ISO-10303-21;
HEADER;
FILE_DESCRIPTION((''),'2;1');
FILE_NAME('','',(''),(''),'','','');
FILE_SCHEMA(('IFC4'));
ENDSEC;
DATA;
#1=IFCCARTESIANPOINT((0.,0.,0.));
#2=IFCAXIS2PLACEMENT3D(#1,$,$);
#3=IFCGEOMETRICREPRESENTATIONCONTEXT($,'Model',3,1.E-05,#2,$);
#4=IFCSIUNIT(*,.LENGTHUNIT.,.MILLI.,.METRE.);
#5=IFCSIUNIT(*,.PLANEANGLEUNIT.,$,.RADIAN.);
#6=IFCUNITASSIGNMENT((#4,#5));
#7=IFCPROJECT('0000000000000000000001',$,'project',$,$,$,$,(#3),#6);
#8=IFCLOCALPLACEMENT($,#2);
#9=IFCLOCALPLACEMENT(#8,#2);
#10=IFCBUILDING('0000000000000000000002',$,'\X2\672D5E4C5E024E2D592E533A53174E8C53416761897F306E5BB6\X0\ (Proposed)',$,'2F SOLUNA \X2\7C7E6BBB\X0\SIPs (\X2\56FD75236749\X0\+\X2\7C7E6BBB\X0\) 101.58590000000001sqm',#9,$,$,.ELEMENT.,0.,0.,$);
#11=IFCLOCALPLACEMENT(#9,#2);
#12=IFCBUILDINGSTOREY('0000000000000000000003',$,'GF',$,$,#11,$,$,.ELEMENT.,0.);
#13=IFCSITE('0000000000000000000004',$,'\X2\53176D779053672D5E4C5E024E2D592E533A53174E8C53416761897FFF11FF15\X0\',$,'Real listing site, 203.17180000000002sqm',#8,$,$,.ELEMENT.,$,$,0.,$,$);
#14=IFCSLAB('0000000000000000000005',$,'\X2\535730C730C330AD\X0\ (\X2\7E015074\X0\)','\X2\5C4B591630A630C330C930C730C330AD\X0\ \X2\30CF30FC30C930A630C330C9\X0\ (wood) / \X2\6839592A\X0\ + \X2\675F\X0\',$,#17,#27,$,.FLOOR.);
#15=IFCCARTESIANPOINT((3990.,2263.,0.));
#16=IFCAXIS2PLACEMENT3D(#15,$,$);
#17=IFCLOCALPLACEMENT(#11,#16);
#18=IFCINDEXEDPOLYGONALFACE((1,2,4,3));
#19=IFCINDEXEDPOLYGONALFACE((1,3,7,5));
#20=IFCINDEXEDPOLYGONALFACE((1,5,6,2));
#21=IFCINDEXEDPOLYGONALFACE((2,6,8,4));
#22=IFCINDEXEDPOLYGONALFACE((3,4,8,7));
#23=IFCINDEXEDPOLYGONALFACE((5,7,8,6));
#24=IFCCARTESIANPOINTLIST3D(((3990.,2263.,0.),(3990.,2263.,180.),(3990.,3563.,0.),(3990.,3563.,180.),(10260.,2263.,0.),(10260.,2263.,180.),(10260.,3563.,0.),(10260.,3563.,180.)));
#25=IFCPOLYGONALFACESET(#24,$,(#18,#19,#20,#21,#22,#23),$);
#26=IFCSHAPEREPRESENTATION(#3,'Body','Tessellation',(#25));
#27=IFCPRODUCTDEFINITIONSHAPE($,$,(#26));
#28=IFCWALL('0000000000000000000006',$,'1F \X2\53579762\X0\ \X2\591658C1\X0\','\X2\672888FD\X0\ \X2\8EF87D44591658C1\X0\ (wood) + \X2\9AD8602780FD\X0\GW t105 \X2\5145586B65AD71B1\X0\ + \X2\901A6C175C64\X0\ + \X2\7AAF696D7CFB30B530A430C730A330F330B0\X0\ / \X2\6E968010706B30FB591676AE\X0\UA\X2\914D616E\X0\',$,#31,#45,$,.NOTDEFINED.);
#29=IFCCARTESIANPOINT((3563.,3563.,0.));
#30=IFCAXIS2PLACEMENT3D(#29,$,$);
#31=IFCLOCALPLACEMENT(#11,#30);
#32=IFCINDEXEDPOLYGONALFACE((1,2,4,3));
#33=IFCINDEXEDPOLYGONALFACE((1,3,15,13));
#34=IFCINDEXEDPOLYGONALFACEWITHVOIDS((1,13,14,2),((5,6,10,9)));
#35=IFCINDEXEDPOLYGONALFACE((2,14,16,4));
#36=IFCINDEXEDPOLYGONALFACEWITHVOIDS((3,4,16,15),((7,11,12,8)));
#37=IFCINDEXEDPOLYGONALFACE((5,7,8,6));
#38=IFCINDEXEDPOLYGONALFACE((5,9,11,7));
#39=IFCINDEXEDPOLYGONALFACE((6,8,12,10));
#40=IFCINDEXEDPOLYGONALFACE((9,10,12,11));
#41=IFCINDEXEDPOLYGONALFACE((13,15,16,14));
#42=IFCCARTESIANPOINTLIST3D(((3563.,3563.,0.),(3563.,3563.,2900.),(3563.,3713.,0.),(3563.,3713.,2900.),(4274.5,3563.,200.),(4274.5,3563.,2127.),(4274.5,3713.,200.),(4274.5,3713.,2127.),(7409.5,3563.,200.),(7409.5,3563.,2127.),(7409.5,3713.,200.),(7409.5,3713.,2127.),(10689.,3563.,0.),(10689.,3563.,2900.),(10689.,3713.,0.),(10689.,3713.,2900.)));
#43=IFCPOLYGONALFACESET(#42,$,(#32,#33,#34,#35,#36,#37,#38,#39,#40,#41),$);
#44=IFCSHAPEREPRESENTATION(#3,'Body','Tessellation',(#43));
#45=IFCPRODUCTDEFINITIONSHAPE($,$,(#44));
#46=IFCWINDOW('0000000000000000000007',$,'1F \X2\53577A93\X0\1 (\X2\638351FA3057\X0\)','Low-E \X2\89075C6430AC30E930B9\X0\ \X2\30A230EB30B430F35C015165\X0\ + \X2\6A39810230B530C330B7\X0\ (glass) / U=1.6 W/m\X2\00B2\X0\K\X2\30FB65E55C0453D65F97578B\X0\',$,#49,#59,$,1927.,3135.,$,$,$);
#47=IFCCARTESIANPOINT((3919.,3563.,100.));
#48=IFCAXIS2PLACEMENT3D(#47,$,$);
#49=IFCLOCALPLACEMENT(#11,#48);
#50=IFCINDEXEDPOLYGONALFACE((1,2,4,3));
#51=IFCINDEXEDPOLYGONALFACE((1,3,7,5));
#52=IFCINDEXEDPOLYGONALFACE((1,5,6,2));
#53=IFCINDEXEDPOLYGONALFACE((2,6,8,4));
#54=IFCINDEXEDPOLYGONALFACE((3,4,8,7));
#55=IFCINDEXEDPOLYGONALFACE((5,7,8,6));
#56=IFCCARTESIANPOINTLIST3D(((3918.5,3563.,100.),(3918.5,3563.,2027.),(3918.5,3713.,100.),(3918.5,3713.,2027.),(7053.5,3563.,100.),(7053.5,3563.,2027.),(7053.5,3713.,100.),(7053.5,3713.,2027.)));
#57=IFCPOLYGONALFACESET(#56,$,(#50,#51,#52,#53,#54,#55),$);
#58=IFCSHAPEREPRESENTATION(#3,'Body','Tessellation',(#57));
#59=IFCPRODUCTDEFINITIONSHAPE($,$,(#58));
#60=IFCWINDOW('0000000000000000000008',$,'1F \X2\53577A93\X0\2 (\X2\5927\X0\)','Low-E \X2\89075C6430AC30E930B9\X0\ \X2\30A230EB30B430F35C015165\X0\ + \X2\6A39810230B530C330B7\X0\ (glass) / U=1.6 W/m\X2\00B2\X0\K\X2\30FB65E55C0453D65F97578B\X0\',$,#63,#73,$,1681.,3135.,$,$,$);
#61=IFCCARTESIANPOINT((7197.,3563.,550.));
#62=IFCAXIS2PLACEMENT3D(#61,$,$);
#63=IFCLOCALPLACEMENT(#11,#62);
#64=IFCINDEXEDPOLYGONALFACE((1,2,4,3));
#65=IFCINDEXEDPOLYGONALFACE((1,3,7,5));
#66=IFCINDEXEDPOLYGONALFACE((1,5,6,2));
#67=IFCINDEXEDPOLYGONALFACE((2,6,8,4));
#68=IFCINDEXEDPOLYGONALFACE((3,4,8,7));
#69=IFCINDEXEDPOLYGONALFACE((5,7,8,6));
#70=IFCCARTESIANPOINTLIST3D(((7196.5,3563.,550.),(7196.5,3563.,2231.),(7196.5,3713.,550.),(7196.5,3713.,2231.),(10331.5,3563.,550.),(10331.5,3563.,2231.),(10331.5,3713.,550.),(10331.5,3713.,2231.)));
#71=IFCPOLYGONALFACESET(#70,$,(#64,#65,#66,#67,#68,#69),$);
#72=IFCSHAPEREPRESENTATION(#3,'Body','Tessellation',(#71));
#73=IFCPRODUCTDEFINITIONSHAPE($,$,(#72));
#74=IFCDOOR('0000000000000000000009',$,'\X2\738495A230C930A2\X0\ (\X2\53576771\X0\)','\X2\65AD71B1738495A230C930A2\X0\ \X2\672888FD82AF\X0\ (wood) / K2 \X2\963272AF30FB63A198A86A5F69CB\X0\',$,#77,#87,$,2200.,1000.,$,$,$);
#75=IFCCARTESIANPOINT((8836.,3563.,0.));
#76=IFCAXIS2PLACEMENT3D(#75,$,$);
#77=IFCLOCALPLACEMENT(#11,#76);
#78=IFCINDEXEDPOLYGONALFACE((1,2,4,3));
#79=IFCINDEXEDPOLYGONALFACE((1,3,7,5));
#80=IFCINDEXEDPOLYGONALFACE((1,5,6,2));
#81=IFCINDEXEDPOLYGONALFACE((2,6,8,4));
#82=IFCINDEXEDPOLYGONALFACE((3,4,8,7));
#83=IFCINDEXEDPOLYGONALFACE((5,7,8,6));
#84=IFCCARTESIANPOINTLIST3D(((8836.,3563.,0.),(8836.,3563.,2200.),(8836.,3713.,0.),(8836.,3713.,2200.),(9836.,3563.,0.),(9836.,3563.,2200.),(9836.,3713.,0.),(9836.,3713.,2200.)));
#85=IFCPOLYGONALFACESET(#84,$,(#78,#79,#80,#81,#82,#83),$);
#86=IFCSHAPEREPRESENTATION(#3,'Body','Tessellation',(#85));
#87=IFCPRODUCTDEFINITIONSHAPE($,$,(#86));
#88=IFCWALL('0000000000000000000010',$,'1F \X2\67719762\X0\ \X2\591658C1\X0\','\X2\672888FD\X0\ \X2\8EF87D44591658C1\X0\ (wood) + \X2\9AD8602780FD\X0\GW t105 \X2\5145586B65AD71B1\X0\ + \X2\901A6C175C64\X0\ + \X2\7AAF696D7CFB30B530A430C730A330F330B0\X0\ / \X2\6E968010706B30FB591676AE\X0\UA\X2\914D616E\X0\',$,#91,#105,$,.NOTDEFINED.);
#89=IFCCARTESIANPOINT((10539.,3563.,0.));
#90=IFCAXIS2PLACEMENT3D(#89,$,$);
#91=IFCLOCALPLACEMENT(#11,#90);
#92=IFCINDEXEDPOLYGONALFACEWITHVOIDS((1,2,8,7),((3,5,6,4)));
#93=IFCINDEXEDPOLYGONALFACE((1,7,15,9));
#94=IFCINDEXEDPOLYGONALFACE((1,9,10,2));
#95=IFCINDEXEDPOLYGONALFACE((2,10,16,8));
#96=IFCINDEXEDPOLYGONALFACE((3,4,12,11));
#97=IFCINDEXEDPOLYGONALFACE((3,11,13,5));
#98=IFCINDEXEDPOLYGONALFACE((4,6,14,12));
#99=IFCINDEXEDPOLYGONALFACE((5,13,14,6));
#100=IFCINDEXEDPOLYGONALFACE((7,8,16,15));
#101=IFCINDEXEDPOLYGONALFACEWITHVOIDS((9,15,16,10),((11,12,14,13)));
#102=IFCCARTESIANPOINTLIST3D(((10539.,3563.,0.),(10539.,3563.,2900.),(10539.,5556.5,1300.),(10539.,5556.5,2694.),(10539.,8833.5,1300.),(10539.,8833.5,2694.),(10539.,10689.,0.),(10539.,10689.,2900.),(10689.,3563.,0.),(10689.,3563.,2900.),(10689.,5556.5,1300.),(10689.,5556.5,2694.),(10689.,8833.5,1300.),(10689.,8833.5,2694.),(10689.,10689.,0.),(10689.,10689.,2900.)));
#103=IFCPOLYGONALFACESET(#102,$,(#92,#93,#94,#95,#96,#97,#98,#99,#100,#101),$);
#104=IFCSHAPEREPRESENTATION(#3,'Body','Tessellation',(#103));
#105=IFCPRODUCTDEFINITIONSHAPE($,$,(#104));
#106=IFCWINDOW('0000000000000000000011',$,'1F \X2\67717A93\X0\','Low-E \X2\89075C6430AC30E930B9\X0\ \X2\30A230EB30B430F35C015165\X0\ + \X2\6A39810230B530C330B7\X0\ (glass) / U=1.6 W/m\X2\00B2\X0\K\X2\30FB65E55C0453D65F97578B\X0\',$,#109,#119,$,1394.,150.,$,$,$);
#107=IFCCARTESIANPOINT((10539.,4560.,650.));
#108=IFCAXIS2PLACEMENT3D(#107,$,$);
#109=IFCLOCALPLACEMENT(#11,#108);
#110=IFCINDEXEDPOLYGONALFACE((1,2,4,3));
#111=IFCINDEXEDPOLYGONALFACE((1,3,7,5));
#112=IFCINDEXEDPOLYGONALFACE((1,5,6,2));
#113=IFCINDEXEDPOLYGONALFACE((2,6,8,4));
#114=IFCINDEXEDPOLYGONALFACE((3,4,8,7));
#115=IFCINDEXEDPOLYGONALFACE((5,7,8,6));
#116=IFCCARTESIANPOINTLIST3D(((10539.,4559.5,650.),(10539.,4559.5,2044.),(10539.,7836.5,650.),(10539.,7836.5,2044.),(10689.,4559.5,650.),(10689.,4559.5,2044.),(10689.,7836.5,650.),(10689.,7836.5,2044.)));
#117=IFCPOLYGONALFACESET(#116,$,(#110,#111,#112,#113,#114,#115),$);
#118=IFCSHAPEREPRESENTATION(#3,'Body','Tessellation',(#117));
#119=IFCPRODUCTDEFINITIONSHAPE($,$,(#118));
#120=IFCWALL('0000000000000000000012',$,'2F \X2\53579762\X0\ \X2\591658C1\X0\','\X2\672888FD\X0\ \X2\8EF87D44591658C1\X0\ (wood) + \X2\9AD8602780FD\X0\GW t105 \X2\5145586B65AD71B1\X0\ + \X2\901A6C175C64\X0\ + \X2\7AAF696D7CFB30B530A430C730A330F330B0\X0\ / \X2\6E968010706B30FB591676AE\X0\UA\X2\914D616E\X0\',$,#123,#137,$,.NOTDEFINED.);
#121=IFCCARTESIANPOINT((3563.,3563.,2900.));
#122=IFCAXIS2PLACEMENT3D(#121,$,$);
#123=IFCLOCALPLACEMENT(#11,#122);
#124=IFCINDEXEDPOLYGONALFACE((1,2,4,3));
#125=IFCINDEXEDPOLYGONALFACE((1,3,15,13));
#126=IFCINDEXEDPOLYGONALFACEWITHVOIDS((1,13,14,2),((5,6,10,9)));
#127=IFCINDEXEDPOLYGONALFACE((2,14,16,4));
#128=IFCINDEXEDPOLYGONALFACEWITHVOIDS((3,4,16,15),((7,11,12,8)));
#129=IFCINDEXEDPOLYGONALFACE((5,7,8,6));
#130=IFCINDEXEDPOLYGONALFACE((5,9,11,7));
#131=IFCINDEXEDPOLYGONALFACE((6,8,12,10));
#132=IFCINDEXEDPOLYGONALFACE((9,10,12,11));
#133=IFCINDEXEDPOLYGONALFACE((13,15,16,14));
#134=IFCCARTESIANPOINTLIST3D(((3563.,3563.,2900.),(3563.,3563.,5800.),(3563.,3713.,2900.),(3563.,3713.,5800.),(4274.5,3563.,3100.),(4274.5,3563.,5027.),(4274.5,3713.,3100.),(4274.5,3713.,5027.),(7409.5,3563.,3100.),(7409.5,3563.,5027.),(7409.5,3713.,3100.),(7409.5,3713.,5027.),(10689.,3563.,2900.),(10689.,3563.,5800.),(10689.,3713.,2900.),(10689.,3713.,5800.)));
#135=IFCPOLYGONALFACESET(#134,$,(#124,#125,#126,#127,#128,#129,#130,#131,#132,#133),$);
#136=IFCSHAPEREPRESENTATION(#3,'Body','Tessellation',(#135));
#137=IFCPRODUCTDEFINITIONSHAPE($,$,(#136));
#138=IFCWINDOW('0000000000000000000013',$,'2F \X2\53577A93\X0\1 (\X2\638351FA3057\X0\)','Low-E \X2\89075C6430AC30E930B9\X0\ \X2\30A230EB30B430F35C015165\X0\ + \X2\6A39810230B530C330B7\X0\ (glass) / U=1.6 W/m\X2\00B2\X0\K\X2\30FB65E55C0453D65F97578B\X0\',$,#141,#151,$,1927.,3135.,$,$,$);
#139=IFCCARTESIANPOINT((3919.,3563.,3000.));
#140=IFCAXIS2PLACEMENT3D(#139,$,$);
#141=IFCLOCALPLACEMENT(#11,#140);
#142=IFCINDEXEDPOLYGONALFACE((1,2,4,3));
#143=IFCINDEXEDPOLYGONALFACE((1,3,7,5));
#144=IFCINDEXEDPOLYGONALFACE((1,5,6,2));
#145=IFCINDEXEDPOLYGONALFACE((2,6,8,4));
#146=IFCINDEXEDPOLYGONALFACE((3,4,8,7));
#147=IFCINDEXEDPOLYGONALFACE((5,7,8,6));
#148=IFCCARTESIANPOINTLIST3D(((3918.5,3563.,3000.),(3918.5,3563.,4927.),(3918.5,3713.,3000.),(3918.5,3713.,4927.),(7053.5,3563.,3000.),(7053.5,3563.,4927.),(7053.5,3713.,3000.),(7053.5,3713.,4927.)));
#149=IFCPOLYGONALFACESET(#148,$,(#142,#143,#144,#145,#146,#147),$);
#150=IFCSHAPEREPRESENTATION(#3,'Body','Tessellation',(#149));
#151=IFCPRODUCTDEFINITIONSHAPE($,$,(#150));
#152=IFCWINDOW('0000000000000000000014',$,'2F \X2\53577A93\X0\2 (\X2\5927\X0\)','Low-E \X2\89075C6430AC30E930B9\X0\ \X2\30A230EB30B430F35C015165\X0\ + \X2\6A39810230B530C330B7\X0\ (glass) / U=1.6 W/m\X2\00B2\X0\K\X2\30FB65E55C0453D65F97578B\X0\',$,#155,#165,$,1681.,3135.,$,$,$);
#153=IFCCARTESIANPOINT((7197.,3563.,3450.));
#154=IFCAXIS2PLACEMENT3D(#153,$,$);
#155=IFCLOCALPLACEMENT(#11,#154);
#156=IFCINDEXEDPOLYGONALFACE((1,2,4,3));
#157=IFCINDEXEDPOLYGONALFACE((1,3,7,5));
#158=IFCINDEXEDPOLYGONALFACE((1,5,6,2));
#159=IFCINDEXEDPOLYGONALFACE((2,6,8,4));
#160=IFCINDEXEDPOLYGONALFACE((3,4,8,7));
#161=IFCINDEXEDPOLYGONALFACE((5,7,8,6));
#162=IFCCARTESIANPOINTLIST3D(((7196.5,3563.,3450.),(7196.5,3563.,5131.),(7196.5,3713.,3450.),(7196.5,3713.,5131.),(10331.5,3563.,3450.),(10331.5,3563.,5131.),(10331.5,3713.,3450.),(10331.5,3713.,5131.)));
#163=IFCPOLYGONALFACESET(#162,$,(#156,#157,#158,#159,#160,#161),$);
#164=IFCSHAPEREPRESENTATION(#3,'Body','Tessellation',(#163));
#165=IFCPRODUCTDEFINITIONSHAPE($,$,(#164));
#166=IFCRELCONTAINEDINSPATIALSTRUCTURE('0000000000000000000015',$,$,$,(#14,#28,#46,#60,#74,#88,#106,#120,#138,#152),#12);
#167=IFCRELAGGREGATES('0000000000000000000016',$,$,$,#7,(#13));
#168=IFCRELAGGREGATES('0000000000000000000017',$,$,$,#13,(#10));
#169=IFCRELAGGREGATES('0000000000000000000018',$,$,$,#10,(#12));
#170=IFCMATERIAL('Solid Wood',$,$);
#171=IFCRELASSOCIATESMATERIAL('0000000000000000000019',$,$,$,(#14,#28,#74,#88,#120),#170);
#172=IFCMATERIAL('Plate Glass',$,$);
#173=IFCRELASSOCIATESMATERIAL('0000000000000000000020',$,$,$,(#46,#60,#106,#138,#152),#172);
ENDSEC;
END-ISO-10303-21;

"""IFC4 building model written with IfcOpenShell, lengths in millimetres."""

from ifc_helpers import new_model, si_unit, frame, frame_2d, origin, place, context, project, spatial, rectangle, extrude, material, element, fill, save


model = new_model("IFC4")

# Units and contexts
model_context = context("Model", 3, precision=1e-05, world=origin())
ifc_project = project(units=[si_unit("LENGTHUNIT", "METRE", prefix="MILLI"), si_unit("PLANEANGLEUNIT", "RADIAN")], contexts=[model_context])

# Site, building, storey
site_placement = place(None, origin())
site = spatial("IfcSite", under=ifc_project, at=site_placement, Name="北海道札幌市中央区北二十条西１５", ObjectType="Real listing site, 203.17180000000002sqm", CompositionType="ELEMENT", RefElevation=0.0)
building_placement = place(site_placement, origin())
building = spatial("IfcBuilding", under=site, at=building_placement, Name="札幌市中央区北二十条西の家 (Proposed)", ObjectType="2F SOLUNA 籾殻SIPs (国産杉+籾殻) 101.58590000000001sqm", CompositionType="ELEMENT", ElevationOfRefHeight=0.0, ElevationOfTerrain=0.0)
storey_placement = place(building_placement, origin())
storey = spatial("IfcBuildingStorey", under=building, at=storey_placement, Name="GF", CompositionType="ELEMENT", Elevation=0.0)

# Slab
ifc_material_1 = material(Name="Solid Wood")
slab_1_placement = place(storey_placement, frame((3990.0, 2263.0, 0.0)))
element("IfcSlab", 1, at=slab_1_placement, inside=storey, material=ifc_material_1, Name="南デッキ (縁側)", Description="屋外ウッドデッキ ハードウッド (wood) / 根太 + 束", PredefinedType="FLOOR", context=model_context, shape_type="SweptSolid", body=[
    extrude(rectangle(XDim=6270.0, YDim=1300.0, at=frame_2d((3135.0, 650.0))), frame((3990.0, 2263.0, 0.0)), (0.0, 0.0, 1.0), 180.0),
])

# Wall, openings, windows, door
wall_1_placement = place(storey_placement, frame((3563.0, 3563.0, 0.0)))
wall_1 = element("IfcWall", 2, at=wall_1_placement, inside=storey, material=ifc_material_1, Name="1F 南面 外壁", Description="木製 軸組外壁 (wood) + 高性能GW t105 充填断熱 + 通気層 + 窯業系サイディング / 準耐火・外皮UA配慮", PredefinedType="NOTDEFINED", context=model_context, shape_type="SweptSolid", body=[
    extrude(rectangle(XDim=7126.0, YDim=150.0, at=frame_2d((3563.0, 75.0))), frame((3563.0, 3563.0, 0.0)), (0.0, 0.0, 1.0), 2900.0),
])
opening_1_placement = place(storey_placement, frame((3919.0, 3563.0, 100.0)))
opening_1 = element("IfcOpeningElement", 3, at=opening_1_placement, cuts=wall_1, PredefinedType="NOTDEFINED", context=model_context, shape_type="SweptSolid", body=[
    extrude(rectangle(XDim=3135.0, YDim=150.0, at=frame_2d((1567.0, 75.0))), frame((3919.0, 3563.0, 100.0)), (0.0, 0.0, 1.0), 1927.0),
])
opening_2_placement = place(storey_placement, frame((7197.0, 3563.0, 550.0)))
opening_2 = element("IfcOpeningElement", 4, at=opening_2_placement, cuts=wall_1, PredefinedType="NOTDEFINED", context=model_context, shape_type="SweptSolid", body=[
    extrude(rectangle(XDim=3135.0, YDim=150.0, at=frame_2d((1567.0, 75.0))), frame((7197.0, 3563.0, 550.0)), (0.0, 0.0, 1.0), 1681.0),
])
opening_3_placement = place(storey_placement, frame((8836.0, 3563.0, 0.0)))
opening_3 = element("IfcOpeningElement", 5, at=opening_3_placement, cuts=wall_1, PredefinedType="NOTDEFINED", context=model_context, shape_type="SweptSolid", body=[
    extrude(rectangle(XDim=1000.0, YDim=150.0, at=frame_2d((500.0, 75.0))), frame((8836.0, 3563.0, 0.0)), (0.0, 0.0, 1.0), 2200.0),
])
ifc_material_2 = material(Name="Plate Glass")
window_1_placement = place(storey_placement, frame((3919.0, 3563.0, 100.0)))
window_1 = element("IfcWindow", 6, at=window_1_placement, inside=storey, material=ifc_material_2, Name="1F 南窓1 (掃出し)", Description="Low-E 複層ガラス アルゴン封入 + 樹脂サッシ (glass) / U=1.6 W/m²K・日射取得型", OverallHeight=1927.0, OverallWidth=3135.0, context=model_context, shape_type="SweptSolid", body=[
    extrude(rectangle(XDim=3135.0, YDim=150.0, at=frame_2d((1567.0, 75.0))), frame((3919.0, 3563.0, 100.0)), (0.0, 0.0, 1.0), 1927.0),
])
fill(opening_1, window_1)
window_2_placement = place(storey_placement, frame((7197.0, 3563.0, 550.0)))
window_2 = element("IfcWindow", 7, at=window_2_placement, inside=storey, material=ifc_material_2, Name="1F 南窓2 (大)", Description="Low-E 複層ガラス アルゴン封入 + 樹脂サッシ (glass) / U=1.6 W/m²K・日射取得型", OverallHeight=1681.0, OverallWidth=3135.0, context=model_context, shape_type="SweptSolid", body=[
    extrude(rectangle(XDim=3135.0, YDim=150.0, at=frame_2d((1567.0, 75.0))), frame((7197.0, 3563.0, 550.0)), (0.0, 0.0, 1.0), 1681.0),
])
fill(opening_2, window_2)
door_placement = place(storey_placement, frame((8836.0, 3563.0, 0.0)))
door = element("IfcDoor", 8, at=door_placement, inside=storey, material=ifc_material_1, Name="玄関ドア (南東)", Description="断熱玄関ドア 木製芯 (wood) / K2 防犯・採風機構", OverallHeight=2200.0, OverallWidth=1000.0, context=model_context, shape_type="SweptSolid", body=[
    extrude(rectangle(XDim=1000.0, YDim=150.0, at=frame_2d((500.0, 75.0))), frame((8836.0, 3563.0, 0.0)), (0.0, 0.0, 1.0), 2200.0),
])
fill(opening_3, door)

# Wall, opening, window
wall_2_placement = place(storey_placement, frame((10539.0, 3563.0, 0.0)))
wall_2 = element("IfcWall", 9, at=wall_2_placement, inside=storey, material=ifc_material_1, Name="1F 東面 外壁", Description="木製 軸組外壁 (wood) + 高性能GW t105 充填断熱 + 通気層 + 窯業系サイディング / 準耐火・外皮UA配慮", PredefinedType="NOTDEFINED", context=model_context, shape_type="SweptSolid", body=[
    extrude(rectangle(XDim=150.0, YDim=7126.0, at=frame_2d((75.0, 3563.0))), frame((10539.0, 3563.0, 0.0)), (0.0, 0.0, 1.0), 2900.0),
])
opening_4_placement = place(storey_placement, frame((10539.0, 4560.0, 650.0)))
opening_4 = element("IfcOpeningElement", 10, at=opening_4_placement, cuts=wall_2, PredefinedType="NOTDEFINED", context=model_context, shape_type="SweptSolid", body=[
    extrude(rectangle(XDim=150.0, YDim=3277.0, at=frame_2d((75.0, 1638.0))), frame((10539.0, 4560.0, 650.0)), (0.0, 0.0, 1.0), 1394.0),
])
window_3_placement = place(storey_placement, frame((10539.0, 4560.0, 650.0)))
window_3 = element("IfcWindow", 11, at=window_3_placement, inside=storey, material=ifc_material_2, Name="1F 東窓", Description="Low-E 複層ガラス アルゴン封入 + 樹脂サッシ (glass) / U=1.6 W/m²K・日射取得型", OverallHeight=1394.0, OverallWidth=150.0, context=model_context, shape_type="SweptSolid", body=[
    extrude(rectangle(XDim=150.0, YDim=3277.0, at=frame_2d((75.0, 1638.0))), frame((10539.0, 4560.0, 650.0)), (0.0, 0.0, 1.0), 1394.0),
])
fill(opening_4, window_3)

# Wall, openings, windows
wall_3_placement = place(storey_placement, frame((3563.0, 3563.0, 2900.0)))
wall_3 = element("IfcWall", 12, at=wall_3_placement, inside=storey, material=ifc_material_1, Name="2F 南面 外壁", Description="木製 軸組外壁 (wood) + 高性能GW t105 充填断熱 + 通気層 + 窯業系サイディング / 準耐火・外皮UA配慮", PredefinedType="NOTDEFINED", context=model_context, shape_type="SweptSolid", body=[
    extrude(rectangle(XDim=7126.0, YDim=150.0, at=frame_2d((3563.0, 75.0))), frame((3563.0, 3563.0, 2900.0)), (0.0, 0.0, 1.0), 2900.0),
])
opening_5_placement = place(storey_placement, frame((3919.0, 3563.0, 3000.0)))
opening_5 = element("IfcOpeningElement", 13, at=opening_5_placement, cuts=wall_3, PredefinedType="NOTDEFINED", context=model_context, shape_type="SweptSolid", body=[
    extrude(rectangle(XDim=3135.0, YDim=150.0, at=frame_2d((1567.0, 75.0))), frame((3919.0, 3563.0, 3000.0)), (0.0, 0.0, 1.0), 1927.0),
])
opening_6_placement = place(storey_placement, frame((7197.0, 3563.0, 3450.0)))
opening_6 = element("IfcOpeningElement", 14, at=opening_6_placement, cuts=wall_3, PredefinedType="NOTDEFINED", context=model_context, shape_type="SweptSolid", body=[
    extrude(rectangle(XDim=3135.0, YDim=150.0, at=frame_2d((1567.0, 75.0))), frame((7197.0, 3563.0, 3450.0)), (0.0, 0.0, 1.0), 1681.0),
])
window_4_placement = place(storey_placement, frame((3919.0, 3563.0, 3000.0)))
window_4 = element("IfcWindow", 15, at=window_4_placement, inside=storey, material=ifc_material_2, Name="2F 南窓1 (掃出し)", Description="Low-E 複層ガラス アルゴン封入 + 樹脂サッシ (glass) / U=1.6 W/m²K・日射取得型", OverallHeight=1927.0, OverallWidth=3135.0, context=model_context, shape_type="SweptSolid", body=[
    extrude(rectangle(XDim=3135.0, YDim=150.0, at=frame_2d((1567.0, 75.0))), frame((3919.0, 3563.0, 3000.0)), (0.0, 0.0, 1.0), 1927.0),
])
fill(opening_5, window_4)
window_5_placement = place(storey_placement, frame((7197.0, 3563.0, 3450.0)))
window_5 = element("IfcWindow", 16, at=window_5_placement, inside=storey, material=ifc_material_2, Name="2F 南窓2 (大)", Description="Low-E 複層ガラス アルゴン封入 + 樹脂サッシ (glass) / U=1.6 W/m²K・日射取得型", OverallHeight=1681.0, OverallWidth=3135.0, context=model_context, shape_type="SweptSolid", body=[
    extrude(rectangle(XDim=3135.0, YDim=150.0, at=frame_2d((1567.0, 75.0))), frame((7197.0, 3563.0, 3450.0)), (0.0, 0.0, 1.0), 1681.0),
])
fill(opening_6, window_5)

save(model, "model.ifc")
